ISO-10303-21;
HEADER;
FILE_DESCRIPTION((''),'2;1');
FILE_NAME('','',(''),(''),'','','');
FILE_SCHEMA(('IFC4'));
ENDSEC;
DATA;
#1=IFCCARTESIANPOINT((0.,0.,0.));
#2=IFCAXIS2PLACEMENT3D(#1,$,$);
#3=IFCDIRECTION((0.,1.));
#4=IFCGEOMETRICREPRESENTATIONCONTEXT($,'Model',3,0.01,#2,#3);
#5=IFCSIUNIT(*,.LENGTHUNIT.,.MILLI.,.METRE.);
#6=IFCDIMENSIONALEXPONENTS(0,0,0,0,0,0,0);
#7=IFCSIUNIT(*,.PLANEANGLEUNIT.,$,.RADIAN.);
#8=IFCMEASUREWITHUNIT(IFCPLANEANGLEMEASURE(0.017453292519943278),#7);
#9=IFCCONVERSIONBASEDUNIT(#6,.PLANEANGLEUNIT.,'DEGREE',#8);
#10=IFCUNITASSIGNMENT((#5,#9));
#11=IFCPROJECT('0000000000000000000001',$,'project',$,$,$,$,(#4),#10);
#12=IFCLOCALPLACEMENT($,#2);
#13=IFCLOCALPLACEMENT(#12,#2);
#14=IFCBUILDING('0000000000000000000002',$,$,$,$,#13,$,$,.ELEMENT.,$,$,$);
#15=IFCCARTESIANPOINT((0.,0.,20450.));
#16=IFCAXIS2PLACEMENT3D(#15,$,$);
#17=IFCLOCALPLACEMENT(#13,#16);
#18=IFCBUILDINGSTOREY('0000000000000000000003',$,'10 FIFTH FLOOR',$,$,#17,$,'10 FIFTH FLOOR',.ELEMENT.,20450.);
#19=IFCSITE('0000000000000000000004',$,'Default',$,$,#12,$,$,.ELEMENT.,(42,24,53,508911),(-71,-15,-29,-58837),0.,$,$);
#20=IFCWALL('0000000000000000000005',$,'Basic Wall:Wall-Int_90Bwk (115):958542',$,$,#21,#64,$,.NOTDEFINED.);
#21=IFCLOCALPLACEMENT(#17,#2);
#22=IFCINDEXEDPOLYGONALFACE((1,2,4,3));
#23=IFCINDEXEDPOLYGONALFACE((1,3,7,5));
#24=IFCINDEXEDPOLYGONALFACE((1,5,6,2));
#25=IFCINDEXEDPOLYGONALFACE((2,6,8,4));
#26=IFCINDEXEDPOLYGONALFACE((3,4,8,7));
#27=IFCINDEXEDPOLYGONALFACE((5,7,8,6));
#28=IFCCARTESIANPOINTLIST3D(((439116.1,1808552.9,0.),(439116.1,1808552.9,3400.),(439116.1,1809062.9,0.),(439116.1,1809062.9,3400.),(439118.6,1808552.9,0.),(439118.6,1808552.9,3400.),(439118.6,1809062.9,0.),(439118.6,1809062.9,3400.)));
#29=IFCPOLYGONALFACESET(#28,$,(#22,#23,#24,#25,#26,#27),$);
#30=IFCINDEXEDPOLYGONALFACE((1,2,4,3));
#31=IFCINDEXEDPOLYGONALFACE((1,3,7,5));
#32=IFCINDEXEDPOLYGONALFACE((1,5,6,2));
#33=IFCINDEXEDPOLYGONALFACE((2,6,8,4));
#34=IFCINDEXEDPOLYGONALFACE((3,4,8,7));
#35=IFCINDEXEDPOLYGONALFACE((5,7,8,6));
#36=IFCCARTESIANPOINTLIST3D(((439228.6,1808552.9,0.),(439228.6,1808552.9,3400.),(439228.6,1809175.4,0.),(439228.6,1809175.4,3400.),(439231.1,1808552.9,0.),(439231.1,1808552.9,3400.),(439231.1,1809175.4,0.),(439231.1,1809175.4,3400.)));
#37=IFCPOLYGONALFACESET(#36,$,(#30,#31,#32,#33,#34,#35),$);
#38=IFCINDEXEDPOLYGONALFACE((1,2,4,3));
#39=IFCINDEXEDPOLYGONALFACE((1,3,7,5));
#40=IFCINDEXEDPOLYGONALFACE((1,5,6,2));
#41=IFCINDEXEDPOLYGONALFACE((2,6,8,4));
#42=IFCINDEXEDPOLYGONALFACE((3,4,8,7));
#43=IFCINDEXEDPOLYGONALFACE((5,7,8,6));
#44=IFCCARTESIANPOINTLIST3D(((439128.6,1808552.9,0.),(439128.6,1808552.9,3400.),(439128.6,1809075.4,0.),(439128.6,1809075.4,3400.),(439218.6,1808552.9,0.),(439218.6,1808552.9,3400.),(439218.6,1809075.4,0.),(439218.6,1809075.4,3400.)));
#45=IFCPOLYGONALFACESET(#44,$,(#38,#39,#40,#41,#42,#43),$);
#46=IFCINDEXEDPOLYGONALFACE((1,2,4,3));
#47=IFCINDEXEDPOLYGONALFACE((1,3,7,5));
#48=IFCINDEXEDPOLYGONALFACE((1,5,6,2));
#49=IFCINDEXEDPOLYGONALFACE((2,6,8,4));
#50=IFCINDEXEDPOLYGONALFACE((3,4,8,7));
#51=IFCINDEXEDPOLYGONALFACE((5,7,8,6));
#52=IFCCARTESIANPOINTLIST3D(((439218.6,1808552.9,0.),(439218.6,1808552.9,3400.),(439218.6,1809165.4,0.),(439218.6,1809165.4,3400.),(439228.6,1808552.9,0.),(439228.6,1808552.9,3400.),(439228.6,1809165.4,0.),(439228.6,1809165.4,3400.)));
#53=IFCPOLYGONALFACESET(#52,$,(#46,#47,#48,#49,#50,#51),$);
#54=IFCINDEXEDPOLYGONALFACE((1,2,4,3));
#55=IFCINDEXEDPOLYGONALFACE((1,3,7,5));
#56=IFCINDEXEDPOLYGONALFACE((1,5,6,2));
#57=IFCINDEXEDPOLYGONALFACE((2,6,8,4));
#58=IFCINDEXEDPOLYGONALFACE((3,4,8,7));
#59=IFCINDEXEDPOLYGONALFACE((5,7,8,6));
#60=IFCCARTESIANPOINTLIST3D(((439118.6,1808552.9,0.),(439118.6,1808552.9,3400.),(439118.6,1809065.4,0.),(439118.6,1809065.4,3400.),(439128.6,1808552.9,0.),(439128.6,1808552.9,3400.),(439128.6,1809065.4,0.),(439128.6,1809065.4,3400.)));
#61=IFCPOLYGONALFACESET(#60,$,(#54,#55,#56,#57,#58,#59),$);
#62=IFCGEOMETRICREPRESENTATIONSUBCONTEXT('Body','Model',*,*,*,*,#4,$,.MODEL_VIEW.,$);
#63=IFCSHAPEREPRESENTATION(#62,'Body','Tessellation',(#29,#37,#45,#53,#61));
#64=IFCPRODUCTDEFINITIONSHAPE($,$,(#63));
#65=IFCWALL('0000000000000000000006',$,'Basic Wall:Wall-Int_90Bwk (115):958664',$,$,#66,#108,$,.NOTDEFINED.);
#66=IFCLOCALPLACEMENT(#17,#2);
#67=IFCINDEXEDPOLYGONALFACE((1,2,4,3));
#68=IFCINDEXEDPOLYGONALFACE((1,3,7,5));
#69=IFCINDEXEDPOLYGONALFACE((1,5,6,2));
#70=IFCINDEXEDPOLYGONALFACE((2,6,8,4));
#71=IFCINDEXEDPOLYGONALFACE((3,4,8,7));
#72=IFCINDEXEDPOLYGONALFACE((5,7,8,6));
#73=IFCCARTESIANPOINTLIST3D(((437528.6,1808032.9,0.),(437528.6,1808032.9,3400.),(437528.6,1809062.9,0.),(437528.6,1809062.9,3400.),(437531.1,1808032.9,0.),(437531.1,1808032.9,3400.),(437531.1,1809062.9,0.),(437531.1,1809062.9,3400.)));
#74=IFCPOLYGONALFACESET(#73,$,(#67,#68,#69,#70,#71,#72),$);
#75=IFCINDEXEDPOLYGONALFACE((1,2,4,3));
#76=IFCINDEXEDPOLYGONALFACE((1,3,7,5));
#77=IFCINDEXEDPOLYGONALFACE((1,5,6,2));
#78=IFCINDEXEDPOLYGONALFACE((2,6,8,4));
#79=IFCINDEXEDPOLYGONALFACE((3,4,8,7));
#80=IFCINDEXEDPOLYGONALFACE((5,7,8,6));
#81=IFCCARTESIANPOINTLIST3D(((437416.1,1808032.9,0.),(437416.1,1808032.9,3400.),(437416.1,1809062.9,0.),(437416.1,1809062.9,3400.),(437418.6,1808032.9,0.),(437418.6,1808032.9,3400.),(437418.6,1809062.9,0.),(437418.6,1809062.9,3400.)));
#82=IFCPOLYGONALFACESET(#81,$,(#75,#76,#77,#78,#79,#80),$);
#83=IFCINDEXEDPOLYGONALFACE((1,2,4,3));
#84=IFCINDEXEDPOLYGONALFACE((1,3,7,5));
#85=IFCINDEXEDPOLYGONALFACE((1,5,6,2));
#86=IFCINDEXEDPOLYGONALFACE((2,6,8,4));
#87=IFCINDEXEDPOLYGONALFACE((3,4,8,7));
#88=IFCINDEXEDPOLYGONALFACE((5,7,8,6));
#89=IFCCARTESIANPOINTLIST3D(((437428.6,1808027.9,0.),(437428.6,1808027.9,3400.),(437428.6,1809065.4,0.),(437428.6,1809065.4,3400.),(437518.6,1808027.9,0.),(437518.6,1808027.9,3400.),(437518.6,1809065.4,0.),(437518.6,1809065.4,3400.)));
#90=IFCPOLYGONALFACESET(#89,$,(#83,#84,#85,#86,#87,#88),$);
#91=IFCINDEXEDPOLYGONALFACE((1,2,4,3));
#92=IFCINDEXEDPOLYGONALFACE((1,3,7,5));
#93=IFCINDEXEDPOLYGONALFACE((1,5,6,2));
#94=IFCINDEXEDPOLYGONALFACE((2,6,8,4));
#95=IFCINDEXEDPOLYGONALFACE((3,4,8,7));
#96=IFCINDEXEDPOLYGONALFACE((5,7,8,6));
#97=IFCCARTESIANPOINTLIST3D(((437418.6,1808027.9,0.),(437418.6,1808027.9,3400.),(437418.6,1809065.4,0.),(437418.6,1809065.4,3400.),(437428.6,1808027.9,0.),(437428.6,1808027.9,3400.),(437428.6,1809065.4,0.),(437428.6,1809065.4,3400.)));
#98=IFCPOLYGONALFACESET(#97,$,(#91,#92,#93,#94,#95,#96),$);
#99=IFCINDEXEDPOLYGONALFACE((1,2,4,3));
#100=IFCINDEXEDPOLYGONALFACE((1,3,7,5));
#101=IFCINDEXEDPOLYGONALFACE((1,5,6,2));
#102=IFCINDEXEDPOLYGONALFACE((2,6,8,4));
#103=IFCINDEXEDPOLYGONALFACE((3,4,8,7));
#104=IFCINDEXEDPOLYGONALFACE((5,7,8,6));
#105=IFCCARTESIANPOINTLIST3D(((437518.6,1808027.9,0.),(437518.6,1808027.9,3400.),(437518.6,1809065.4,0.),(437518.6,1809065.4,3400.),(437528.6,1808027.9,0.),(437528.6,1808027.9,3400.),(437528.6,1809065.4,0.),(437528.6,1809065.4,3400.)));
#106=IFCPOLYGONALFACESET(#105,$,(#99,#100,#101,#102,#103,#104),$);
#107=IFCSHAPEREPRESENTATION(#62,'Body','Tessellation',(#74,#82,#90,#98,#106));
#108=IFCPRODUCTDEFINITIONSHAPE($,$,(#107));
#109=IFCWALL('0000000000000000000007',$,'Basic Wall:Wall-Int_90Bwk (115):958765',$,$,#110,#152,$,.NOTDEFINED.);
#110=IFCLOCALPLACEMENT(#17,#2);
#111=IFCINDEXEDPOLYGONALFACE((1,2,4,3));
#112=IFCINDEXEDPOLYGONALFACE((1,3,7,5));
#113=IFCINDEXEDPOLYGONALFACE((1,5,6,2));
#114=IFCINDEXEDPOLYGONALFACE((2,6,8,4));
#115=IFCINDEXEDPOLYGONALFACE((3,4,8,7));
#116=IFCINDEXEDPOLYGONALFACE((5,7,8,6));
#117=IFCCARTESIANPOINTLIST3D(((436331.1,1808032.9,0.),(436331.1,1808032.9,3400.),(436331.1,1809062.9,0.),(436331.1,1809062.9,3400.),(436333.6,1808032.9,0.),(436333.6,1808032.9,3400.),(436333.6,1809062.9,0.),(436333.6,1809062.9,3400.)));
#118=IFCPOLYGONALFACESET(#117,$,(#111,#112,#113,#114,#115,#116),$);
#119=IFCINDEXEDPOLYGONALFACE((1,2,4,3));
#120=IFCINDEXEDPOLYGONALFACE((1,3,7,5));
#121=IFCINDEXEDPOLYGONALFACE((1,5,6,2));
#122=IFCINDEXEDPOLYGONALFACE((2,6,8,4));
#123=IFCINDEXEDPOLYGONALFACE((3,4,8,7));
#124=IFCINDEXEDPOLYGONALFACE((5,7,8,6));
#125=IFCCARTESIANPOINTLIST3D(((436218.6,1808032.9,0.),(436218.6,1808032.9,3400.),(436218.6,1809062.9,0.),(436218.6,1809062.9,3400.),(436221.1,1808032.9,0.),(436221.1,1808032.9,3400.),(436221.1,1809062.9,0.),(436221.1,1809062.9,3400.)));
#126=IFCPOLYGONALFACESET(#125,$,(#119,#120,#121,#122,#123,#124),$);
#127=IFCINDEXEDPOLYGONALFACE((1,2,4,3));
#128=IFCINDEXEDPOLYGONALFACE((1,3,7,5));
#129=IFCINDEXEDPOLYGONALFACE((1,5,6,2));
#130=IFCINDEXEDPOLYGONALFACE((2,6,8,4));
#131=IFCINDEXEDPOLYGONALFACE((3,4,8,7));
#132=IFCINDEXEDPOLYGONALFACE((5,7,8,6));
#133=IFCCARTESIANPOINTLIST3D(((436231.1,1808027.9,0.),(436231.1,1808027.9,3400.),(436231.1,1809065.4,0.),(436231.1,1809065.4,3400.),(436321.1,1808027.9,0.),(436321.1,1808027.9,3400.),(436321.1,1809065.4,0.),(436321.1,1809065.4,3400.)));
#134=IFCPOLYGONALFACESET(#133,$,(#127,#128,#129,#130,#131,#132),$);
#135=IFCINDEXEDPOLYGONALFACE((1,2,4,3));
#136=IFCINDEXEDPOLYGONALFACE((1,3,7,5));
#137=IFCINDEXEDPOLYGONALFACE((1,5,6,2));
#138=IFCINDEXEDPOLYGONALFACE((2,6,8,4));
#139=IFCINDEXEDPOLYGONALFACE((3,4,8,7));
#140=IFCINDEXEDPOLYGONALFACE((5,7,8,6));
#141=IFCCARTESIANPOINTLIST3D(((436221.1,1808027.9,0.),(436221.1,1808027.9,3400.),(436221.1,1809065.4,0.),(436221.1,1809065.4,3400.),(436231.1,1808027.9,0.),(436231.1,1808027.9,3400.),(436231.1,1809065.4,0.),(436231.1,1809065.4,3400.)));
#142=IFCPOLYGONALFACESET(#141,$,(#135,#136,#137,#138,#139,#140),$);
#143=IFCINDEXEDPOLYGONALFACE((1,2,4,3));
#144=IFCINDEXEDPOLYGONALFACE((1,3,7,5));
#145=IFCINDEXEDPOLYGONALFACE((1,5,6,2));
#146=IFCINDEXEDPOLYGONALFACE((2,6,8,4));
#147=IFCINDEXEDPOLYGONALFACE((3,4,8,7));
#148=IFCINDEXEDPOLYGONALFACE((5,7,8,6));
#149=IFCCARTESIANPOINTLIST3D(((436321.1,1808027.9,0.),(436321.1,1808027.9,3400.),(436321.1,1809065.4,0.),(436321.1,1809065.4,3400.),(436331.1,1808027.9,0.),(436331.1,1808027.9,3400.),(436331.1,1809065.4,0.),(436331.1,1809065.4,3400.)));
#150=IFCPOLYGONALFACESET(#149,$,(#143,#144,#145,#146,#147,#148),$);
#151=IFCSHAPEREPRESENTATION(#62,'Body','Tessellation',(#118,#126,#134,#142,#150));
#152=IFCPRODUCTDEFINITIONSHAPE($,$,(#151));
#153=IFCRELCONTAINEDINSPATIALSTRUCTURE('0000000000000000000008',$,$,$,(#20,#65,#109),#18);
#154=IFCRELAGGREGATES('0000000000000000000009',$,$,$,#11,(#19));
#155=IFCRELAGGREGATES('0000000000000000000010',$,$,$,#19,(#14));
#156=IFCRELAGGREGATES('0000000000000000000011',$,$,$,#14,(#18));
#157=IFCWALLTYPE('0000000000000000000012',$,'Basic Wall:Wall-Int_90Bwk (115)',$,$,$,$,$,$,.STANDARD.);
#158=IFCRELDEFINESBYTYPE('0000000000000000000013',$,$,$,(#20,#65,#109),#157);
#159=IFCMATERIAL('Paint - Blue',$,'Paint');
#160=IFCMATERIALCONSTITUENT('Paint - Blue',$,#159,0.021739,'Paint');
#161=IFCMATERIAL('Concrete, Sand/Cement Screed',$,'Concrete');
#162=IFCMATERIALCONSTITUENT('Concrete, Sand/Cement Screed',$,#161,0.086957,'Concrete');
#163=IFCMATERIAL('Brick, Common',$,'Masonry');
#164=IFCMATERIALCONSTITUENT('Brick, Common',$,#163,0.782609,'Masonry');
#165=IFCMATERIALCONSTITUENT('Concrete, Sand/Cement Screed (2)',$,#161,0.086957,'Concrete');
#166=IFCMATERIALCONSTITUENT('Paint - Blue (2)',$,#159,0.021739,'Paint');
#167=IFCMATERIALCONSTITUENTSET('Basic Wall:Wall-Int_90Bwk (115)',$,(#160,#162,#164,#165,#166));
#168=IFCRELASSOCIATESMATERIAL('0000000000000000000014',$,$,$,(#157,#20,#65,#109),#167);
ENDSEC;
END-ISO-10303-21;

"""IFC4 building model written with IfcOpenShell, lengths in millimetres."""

from ifc_helpers import new_model, entity, si_unit, converted_unit, direction, frame, origin, place, context, subcontext, project, spatial, indexed_curve, outline, extrude, material, constituent, constituent_set, type_object, element, save


model = new_model("IFC4")

# Units and contexts
model_context = context("Model", 3, precision=0.01, world=origin(), true_north=direction((0.0, 1.0)))
body_context = subcontext(model_context, "Body", "Model", "MODEL_VIEW")
ifc_project = project(units=[si_unit("LENGTHUNIT", "METRE", prefix="MILLI"), converted_unit("PLANEANGLEUNIT", "DEGREE", entity("IfcPlaneAngleMeasure", 0.017453292519943278), si_unit("PLANEANGLEUNIT", "RADIAN"), dimensions=[0, 0, 0, 0, 0, 0, 0])], contexts=[model_context])

# Site, building, storey
site_placement = place(None, origin())
site = spatial("IfcSite", under=ifc_project, at=site_placement, Name="Default", CompositionType="ELEMENT", RefLatitude=(42, 24, 53, 508911), RefLongitude=(-71, -15, -29, -58837), RefElevation=0.0)
building_placement = place(site_placement, origin())
building = spatial("IfcBuilding", under=site, at=building_placement, CompositionType="ELEMENT")
storey_placement = place(building_placement, frame((0.0, 0.0, 20450.0)))
storey = spatial("IfcBuildingStorey", under=building, at=storey_placement, Name="10 FIFTH FLOOR", LongName="10 FIFTH FLOOR", CompositionType="ELEMENT", Elevation=20450.0)

# Shared definitions
ifc_material_1 = material(Name="Paint - Blue", Category="Paint")
ifc_constituent_1 = constituent(ifc_material_1, Name="Paint - Blue", Category="Paint", fraction=0.021739)
ifc_material_2 = material(Name="Concrete, Sand/Cement Screed", Category="Concrete")
ifc_constituent_2 = constituent(ifc_material_2, Name="Concrete, Sand/Cement Screed", Category="Concrete", fraction=0.086957)
ifc_material_3 = material(Name="Brick, Common", Category="Masonry")
ifc_constituent_3 = constituent(ifc_material_3, Name="Brick, Common", Category="Masonry", fraction=0.782609)
ifc_constituent_4 = constituent(ifc_material_2, Name="Concrete, Sand/Cement Screed (2)", Category="Concrete", fraction=0.086957)
ifc_constituent_5 = constituent(ifc_material_1, Name="Paint - Blue (2)", Category="Paint", fraction=0.021739)
ifc_constituent_set_1 = constituent_set(constituents=[ifc_constituent_1, ifc_constituent_2, ifc_constituent_3, ifc_constituent_4, ifc_constituent_5], Name="Basic Wall:Wall-Int_90Bwk (115)")
wall_type_1 = type_object("IfcWallType", Name="Basic Wall:Wall-Int_90Bwk (115)", PredefinedType="STANDARD", material=ifc_constituent_set_1)

# Walls
wall_1_placement = place(storey_placement, frame((439173.6, 1809062.9, 0.0), z_axis=(0.0, 0.0, 1.0), x_axis=(0.0, -1.0, 0.0)))
element("IfcWall", 1, at=wall_1_placement, inside=storey, type_object=wall_type_1, material=ifc_constituent_set_1, Name="Basic Wall:Wall-Int_90Bwk (115):958542", PredefinedType="NOTDEFINED", context=body_context, shape_type="SweptSolid", body=[
    extrude(outline(indexed_curve([(-1.3, -255.0), (1.2, -255.0), (1.2, 255.0), (-1.3, 255.0), (-1.3, -255.0)], self_intersect=False)), frame((255.0, -56.2, 0.0), z_axis=(0.0, 0.0, 1.0), x_axis=(0.0, 1.0, 0.0)), (0.0, 0.0, 1.0), 3400.0),
    extrude(outline(indexed_curve([(-1.3, -311.3), (1.2, -311.3), (1.2, 311.3), (-1.3, 311.3), (-1.3, -311.3)], self_intersect=False)), frame((198.8, 56.2, 0.0), z_axis=(0.0, 0.0, 1.0), x_axis=(0.0, -1.0, 0.0)), (0.0, 0.0, 1.0), 3400.0),
    extrude(outline(indexed_curve([(-261.3, -45.0), (261.3, -45.0), (261.3, 45.0), (-261.3, 45.0), (-261.3, -45.0)], self_intersect=False)), frame((248.8, 0.0, 0.0)), (0.0, 0.0, 1.0), 3400.0),
    extrude(outline(indexed_curve([(-306.3, -5.0), (306.3, -5.0), (306.3, 5.0), (-306.3, 5.0), (-306.3, -5.0)], self_intersect=False)), frame((203.8, 50.0, 0.0)), (0.0, 0.0, 1.0), 3400.0),
    extrude(outline(indexed_curve([(-256.3, -5.0), (256.3, -5.0), (256.3, 5.0), (-256.3, 5.0), (-256.3, -5.0)], self_intersect=False)), frame((253.8, -50.0, 0.0)), (0.0, 0.0, 1.0), 3400.0),
])
wall_2_placement = place(storey_placement, frame((437473.6, 1809062.9, 0.0), z_axis=(0.0, 0.0, 1.0), x_axis=(0.0, -1.0, 0.0)))
element("IfcWall", 2, at=wall_2_placement, inside=storey, type_object=wall_type_1, material=ifc_constituent_set_1, Name="Basic Wall:Wall-Int_90Bwk (115):958664", PredefinedType="NOTDEFINED", context=body_context, shape_type="SweptSolid", body=[
    extrude(outline(indexed_curve([(-1.3, -515.0), (1.2, -515.0), (1.2, 515.0), (-1.3, 515.0), (-1.3, -515.0)], self_intersect=False)), frame((515.0, 56.2, 0.0), z_axis=(0.0, 0.0, 1.0), x_axis=(0.0, -1.0, 0.0)), (0.0, 0.0, 1.0), 3400.0),
    extrude(outline(indexed_curve([(-1.2, -515.0), (1.3, -515.0), (1.3, 515.0), (-1.2, 515.0), (-1.2, -515.0)], self_intersect=False)), frame((515.0, -56.3, 0.0), z_axis=(0.0, 0.0, 1.0), x_axis=(0.0, 1.0, 0.0)), (0.0, 0.0, 1.0), 3400.0),
    extrude(outline(indexed_curve([(-518.8, -45.0), (518.8, -45.0), (518.8, 45.0), (-518.8, 45.0), (-518.8, -45.0)], self_intersect=False)), frame((516.3, 0.0, 0.0)), (0.0, 0.0, 1.0), 3400.0),
    extrude(outline(indexed_curve([(-518.8, -5.0), (518.8, -5.0), (518.8, 5.0), (-518.8, 5.0), (-518.8, -5.0)], self_intersect=False)), frame((516.3, -50.0, 0.0)), (0.0, 0.0, 1.0), 3400.0),
    extrude(outline(indexed_curve([(-518.8, -5.0), (518.8, -5.0), (518.8, 5.0), (-518.8, 5.0), (-518.8, -5.0)], self_intersect=False)), frame((516.3, 50.0, 0.0)), (0.0, 0.0, 1.0), 3400.0),
])
wall_3_placement = place(storey_placement, frame((436276.1, 1808032.9, 0.0), z_axis=(0.0, 0.0, 1.0), x_axis=(0.0, 1.0, 0.0)))
element("IfcWall", 3, at=wall_3_placement, inside=storey, type_object=wall_type_1, material=ifc_constituent_set_1, Name="Basic Wall:Wall-Int_90Bwk (115):958765", PredefinedType="NOTDEFINED", context=body_context, shape_type="SweptSolid", body=[
    extrude(outline(indexed_curve([(-1.3, -515.0), (1.2, -515.0), (1.2, 515.0), (-1.3, 515.0), (-1.3, -515.0)], self_intersect=False)), frame((515.0, -56.2, 0.0), z_axis=(0.0, 0.0, 1.0), x_axis=(0.0, 1.0, 0.0)), (0.0, 0.0, 1.0), 3400.0),
    extrude(outline(indexed_curve([(-1.3, -515.0), (1.2, -515.0), (1.2, 515.0), (-1.3, 515.0), (-1.3, -515.0)], self_intersect=False)), frame((515.0, 56.2, 0.0), z_axis=(0.0, 0.0, 1.0), x_axis=(0.0, -1.0, 0.0)), (0.0, 0.0, 1.0), 3400.0),
    extrude(outline(indexed_curve([(-518.8, -45.0), (518.8, -45.0), (518.8, 45.0), (-518.8, 45.0), (-518.8, -45.0)], self_intersect=False)), frame((513.8, 0.0, 0.0)), (0.0, 0.0, 1.0), 3400.0),
    extrude(outline(indexed_curve([(-518.8, -5.0), (518.8, -5.0), (518.8, 5.0), (-518.8, 5.0), (-518.8, -5.0)], self_intersect=False)), frame((513.8, 50.0, 0.0)), (0.0, 0.0, 1.0), 3400.0),
    extrude(outline(indexed_curve([(-518.8, -5.0), (518.8, -5.0), (518.8, 5.0), (-518.8, 5.0), (-518.8, -5.0)], self_intersect=False)), frame((513.8, -50.0, 0.0)), (0.0, 0.0, 1.0), 3400.0),
])

save(model, "model.ifc")
